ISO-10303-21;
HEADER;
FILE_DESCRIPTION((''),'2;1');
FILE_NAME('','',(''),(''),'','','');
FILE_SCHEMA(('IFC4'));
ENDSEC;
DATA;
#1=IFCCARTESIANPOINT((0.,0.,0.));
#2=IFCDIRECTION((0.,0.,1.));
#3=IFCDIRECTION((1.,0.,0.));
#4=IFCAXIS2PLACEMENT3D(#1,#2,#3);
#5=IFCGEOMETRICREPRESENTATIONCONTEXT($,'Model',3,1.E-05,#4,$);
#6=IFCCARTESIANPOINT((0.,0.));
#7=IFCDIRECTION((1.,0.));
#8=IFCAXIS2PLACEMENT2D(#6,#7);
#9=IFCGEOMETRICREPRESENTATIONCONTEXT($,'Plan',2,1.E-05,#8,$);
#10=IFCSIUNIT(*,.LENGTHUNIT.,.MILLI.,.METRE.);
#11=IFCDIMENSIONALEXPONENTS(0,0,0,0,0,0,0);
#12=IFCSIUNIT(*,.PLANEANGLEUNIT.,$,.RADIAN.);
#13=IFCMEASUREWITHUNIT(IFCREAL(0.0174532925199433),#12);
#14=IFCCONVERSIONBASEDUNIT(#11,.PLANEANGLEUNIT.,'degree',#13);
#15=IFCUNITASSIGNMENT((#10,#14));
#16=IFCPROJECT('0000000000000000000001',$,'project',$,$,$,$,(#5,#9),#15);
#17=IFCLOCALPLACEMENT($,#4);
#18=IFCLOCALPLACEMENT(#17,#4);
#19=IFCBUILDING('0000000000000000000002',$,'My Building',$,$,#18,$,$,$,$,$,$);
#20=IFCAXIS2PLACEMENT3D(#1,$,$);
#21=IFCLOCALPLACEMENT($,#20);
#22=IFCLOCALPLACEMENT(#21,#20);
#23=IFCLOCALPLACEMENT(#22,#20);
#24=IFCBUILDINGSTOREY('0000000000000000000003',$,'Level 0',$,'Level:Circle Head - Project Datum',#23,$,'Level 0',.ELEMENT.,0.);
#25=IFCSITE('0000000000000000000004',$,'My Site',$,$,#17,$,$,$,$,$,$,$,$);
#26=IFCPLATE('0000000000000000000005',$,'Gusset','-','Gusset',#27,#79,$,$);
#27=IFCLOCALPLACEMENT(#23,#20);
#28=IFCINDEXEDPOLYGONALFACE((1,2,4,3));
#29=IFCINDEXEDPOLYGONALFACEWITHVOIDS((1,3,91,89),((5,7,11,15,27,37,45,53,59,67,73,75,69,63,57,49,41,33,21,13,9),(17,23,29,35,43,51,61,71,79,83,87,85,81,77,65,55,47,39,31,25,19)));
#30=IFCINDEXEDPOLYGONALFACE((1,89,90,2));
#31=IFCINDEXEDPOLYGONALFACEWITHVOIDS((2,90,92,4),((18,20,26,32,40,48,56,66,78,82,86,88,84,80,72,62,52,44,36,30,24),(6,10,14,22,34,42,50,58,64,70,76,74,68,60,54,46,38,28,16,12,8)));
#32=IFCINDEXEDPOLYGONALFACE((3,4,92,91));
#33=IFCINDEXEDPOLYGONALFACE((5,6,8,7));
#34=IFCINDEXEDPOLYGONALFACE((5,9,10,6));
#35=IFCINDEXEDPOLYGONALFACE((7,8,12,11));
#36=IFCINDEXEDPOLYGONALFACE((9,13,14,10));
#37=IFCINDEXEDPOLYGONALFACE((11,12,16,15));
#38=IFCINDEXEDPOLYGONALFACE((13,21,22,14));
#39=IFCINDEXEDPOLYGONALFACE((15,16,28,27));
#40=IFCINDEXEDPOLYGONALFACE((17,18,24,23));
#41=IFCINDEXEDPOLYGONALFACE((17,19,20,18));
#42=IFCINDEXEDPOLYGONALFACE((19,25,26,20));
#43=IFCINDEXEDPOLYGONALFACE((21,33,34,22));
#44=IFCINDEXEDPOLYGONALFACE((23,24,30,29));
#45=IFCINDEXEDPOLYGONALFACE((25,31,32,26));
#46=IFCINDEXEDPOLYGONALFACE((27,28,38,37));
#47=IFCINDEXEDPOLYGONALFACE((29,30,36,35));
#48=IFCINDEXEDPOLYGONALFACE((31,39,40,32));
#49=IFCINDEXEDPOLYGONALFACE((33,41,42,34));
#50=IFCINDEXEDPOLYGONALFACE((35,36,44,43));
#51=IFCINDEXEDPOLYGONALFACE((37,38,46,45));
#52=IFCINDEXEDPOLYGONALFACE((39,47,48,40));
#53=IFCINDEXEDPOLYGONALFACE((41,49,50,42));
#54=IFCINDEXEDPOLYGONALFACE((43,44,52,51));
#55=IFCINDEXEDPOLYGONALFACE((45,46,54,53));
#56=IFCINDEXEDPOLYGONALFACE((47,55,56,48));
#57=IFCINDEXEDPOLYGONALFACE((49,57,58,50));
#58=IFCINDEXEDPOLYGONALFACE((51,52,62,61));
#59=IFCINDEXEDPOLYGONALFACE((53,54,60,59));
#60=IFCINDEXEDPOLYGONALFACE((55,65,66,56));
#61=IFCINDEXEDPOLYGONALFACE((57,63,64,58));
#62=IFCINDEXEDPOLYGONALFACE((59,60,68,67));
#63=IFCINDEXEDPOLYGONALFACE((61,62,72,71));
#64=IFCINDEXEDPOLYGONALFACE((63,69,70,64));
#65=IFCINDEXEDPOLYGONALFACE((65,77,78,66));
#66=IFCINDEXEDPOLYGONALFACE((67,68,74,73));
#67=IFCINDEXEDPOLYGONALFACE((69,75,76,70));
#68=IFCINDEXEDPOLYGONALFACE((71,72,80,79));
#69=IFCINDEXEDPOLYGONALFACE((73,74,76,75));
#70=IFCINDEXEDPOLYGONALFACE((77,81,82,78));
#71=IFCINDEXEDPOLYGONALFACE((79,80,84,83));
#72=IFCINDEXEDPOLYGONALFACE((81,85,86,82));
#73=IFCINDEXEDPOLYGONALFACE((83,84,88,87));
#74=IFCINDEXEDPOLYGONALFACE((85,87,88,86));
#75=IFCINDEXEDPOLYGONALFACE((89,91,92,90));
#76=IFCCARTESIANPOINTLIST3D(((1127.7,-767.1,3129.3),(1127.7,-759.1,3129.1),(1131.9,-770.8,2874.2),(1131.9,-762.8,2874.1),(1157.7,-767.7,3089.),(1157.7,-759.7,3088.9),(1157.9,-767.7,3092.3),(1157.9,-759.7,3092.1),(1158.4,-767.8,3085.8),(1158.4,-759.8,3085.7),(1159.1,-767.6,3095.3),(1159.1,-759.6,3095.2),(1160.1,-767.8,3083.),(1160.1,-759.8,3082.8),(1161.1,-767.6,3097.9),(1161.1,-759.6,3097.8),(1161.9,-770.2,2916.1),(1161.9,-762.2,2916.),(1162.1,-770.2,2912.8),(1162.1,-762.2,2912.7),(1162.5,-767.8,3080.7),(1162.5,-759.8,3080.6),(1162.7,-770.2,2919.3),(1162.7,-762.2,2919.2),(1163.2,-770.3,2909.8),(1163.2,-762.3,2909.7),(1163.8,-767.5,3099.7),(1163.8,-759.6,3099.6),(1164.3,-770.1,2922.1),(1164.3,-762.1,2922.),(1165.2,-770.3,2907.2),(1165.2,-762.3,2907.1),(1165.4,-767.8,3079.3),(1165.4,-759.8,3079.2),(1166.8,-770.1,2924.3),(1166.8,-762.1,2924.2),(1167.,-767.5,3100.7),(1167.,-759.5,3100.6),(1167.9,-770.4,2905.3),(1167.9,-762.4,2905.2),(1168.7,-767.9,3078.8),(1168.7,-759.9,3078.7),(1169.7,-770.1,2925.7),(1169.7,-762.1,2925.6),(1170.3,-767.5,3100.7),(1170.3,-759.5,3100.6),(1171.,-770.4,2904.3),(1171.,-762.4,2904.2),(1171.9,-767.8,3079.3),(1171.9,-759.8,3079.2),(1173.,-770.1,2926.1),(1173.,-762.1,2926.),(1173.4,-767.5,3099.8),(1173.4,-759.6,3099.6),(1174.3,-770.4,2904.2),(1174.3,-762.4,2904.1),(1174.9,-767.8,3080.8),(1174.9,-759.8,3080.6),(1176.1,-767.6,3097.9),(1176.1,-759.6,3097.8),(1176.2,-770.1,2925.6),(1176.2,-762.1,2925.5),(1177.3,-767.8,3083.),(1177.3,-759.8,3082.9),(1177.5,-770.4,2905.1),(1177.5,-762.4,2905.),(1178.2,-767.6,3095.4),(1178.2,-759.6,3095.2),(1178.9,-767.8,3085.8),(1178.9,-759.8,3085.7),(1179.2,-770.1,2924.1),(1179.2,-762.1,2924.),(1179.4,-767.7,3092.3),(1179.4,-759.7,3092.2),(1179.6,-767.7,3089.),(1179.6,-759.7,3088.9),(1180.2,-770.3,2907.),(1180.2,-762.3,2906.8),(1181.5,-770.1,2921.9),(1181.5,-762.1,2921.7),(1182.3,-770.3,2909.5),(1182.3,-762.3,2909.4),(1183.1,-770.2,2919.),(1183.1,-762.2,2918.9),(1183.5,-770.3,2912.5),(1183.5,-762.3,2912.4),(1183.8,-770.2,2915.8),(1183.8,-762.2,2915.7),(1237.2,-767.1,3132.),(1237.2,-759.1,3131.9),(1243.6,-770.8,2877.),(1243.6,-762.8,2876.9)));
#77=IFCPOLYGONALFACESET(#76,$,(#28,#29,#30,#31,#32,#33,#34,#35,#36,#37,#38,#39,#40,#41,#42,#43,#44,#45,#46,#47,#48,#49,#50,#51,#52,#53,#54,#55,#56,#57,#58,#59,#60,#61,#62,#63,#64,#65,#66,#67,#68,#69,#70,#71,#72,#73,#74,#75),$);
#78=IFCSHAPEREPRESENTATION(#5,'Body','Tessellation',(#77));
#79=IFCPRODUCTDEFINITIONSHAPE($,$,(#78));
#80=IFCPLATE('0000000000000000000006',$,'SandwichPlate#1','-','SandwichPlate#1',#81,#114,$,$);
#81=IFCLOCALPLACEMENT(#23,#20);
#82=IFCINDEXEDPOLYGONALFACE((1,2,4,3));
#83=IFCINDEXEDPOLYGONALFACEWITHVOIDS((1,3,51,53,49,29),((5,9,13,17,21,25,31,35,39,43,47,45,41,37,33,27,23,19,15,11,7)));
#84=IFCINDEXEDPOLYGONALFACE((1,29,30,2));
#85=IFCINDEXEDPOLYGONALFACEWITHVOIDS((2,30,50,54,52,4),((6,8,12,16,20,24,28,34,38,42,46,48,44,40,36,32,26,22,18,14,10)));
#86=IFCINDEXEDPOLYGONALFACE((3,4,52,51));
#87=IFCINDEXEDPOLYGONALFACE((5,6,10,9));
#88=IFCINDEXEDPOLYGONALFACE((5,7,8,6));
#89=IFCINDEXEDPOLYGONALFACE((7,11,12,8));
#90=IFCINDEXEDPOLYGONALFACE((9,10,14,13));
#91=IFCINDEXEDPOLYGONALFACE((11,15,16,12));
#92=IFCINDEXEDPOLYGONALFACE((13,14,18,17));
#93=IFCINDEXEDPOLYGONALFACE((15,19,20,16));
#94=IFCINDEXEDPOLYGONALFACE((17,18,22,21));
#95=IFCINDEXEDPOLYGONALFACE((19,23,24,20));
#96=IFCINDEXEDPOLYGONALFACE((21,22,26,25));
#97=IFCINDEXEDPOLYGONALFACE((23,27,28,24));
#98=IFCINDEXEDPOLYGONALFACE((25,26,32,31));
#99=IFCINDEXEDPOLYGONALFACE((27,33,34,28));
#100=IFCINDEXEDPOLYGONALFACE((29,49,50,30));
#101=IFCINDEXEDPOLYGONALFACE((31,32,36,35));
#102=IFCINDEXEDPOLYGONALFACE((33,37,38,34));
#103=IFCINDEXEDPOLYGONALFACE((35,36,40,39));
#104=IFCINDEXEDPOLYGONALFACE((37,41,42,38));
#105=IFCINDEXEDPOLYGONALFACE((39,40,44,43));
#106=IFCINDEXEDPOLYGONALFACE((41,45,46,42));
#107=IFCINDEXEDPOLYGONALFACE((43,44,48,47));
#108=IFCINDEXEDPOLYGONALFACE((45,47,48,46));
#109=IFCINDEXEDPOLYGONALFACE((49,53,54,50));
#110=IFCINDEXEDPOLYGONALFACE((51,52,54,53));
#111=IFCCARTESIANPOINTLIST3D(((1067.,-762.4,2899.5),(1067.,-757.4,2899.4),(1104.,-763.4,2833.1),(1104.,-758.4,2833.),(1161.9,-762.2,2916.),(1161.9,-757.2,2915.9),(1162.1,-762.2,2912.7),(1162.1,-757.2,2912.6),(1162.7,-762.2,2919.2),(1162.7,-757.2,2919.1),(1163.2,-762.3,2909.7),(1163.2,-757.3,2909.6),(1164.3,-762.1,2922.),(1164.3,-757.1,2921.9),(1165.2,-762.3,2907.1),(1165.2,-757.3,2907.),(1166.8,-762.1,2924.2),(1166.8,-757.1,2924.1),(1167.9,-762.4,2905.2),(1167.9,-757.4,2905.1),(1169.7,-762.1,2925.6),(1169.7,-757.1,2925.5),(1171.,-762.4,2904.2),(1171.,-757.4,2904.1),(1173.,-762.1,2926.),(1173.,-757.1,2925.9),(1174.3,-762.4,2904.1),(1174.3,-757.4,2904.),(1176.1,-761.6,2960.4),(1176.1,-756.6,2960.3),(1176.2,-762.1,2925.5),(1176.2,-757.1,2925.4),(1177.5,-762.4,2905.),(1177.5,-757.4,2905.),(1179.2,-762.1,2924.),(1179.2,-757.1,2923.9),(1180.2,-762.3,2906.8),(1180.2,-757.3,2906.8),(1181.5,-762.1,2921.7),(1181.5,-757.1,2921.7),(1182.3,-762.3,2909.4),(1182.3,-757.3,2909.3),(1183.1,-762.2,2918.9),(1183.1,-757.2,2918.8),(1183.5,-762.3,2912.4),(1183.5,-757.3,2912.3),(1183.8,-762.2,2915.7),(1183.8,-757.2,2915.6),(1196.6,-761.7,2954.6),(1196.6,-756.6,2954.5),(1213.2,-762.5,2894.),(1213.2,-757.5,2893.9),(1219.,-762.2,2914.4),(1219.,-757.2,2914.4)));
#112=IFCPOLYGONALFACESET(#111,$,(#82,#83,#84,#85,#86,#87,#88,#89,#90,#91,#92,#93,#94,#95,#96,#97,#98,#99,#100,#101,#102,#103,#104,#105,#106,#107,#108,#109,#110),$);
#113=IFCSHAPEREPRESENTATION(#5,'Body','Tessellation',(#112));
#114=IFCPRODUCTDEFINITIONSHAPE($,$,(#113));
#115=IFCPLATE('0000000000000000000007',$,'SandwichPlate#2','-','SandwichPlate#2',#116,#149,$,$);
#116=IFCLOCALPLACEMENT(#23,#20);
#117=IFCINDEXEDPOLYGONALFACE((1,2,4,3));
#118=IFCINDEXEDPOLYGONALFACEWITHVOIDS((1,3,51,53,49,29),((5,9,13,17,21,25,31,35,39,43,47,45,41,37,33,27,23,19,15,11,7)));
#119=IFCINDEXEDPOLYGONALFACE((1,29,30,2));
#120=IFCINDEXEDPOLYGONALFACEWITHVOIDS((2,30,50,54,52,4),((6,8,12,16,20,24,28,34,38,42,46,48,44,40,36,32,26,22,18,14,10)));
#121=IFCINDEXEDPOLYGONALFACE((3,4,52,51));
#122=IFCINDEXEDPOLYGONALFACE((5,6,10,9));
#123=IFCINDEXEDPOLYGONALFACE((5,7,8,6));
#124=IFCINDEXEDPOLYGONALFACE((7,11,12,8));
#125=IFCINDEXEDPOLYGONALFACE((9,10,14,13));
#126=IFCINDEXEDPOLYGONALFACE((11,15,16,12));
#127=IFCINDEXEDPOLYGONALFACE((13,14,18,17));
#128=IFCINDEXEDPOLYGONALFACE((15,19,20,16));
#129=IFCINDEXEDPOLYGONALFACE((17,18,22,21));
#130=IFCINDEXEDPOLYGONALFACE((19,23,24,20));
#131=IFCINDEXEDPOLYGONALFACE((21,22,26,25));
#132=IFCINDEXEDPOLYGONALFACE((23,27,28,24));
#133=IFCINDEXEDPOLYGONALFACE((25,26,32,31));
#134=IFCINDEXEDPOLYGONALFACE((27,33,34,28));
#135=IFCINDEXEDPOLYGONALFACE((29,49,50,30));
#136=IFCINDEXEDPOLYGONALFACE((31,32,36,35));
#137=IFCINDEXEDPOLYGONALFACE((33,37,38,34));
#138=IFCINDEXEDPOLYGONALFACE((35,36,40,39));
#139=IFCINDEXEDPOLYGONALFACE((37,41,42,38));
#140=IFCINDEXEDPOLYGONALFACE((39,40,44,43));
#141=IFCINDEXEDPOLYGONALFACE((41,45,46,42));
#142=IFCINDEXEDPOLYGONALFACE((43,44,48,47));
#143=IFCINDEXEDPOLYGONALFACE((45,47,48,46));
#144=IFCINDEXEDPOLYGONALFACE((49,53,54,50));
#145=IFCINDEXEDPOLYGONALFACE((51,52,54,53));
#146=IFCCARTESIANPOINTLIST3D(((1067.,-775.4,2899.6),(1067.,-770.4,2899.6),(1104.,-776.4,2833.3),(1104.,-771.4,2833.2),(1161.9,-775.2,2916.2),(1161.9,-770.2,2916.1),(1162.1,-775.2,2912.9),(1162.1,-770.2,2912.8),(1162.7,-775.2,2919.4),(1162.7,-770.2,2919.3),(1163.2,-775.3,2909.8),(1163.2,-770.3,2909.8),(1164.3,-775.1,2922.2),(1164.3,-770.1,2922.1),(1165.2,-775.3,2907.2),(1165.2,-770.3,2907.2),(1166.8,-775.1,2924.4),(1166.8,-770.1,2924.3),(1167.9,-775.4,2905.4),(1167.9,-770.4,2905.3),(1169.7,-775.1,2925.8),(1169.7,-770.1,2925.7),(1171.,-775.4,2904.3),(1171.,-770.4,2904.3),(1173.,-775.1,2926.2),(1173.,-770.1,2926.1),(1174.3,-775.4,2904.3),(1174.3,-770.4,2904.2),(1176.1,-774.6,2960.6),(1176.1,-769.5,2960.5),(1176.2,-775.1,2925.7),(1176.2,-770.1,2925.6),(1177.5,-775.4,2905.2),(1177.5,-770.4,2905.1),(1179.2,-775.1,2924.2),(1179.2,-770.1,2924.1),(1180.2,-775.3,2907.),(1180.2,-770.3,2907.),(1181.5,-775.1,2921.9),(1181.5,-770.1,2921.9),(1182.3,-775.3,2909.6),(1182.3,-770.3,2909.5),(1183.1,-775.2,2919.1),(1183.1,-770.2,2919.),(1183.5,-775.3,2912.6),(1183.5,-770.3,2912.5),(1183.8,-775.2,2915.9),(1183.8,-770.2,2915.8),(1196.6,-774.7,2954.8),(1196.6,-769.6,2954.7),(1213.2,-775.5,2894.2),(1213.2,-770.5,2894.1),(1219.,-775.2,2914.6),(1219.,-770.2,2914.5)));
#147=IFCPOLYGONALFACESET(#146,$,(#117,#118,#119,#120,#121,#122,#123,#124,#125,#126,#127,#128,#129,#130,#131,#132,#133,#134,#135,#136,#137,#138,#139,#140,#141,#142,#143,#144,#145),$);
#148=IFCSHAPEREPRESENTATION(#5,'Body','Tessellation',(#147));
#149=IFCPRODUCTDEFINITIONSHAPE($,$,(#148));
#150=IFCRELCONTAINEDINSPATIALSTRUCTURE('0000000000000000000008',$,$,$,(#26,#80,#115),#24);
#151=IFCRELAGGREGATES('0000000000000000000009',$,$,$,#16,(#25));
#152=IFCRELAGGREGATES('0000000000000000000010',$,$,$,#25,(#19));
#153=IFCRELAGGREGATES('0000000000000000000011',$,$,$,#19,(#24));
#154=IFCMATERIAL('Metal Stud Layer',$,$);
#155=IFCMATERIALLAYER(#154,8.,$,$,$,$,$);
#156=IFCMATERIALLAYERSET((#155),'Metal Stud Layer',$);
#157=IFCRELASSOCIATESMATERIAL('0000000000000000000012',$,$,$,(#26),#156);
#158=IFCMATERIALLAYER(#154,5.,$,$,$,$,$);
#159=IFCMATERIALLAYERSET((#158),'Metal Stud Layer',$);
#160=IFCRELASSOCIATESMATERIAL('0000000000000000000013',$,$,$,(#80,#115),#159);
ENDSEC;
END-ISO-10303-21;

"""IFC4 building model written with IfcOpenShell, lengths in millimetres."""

from ifc_helpers import new_model, entity, si_unit, converted_unit, frame, origin, origin_with_axes, origin_2d_with_axis, place, context, project, spatial, polyline, circle, outline, extrude, material, layer, layer_set, element, save


model = new_model("IFC4")

# Units and contexts
model_context = context("Model", 3, precision=1e-05, world=origin_with_axes())
plan_context = context("Plan", 2, precision=1e-05, world=origin_2d_with_axis())
ifc_project = project(units=[si_unit("LENGTHUNIT", "METRE", prefix="MILLI"), converted_unit("PLANEANGLEUNIT", "degree", entity("IfcReal", 0.0174532925199433), si_unit("PLANEANGLEUNIT", "RADIAN"), dimensions=[0, 0, 0, 0, 0, 0, 0])], contexts=[model_context, plan_context])

# Site, building, storey
site_placement = place(None, origin_with_axes())
site = spatial("IfcSite", under=ifc_project, at=site_placement, Name="My Site")
building_placement = place(site_placement, origin_with_axes())
building = spatial("IfcBuilding", under=site, at=building_placement, Name="My Building")
placement_1 = place(None, origin())
placement_2 = place(placement_1, origin())
storey_placement = place(placement_2, origin())
storey = spatial("IfcBuildingStorey", under=building, at=storey_placement, Name="Level 0", ObjectType="Level:Circle Head - Project Datum", LongName="Level 0", CompositionType="ELEMENT", Elevation=0.0)

# Plates, openings
ifc_material = material(Name="Metal Stud Layer")
ifc_layer_1 = layer(ifc_material, 8.0)
ifc_layer_set_1 = layer_set([ifc_layer_1], Name="Metal Stud Layer")
plate_1_placement = place(storey_placement, frame((1235.2, -767.1, 3131.9), z_axis=(0.0, 0.999896, -0.014432), x_axis=(0.02499, -0.014428, -0.999584)))
plate_1 = element("IfcPlate", 1, at=plate_1_placement, inside=storey, material=ifc_layer_set_1, Name="Gusset", Description="-", ObjectType="Gusset", context=model_context, shape_type="SweptSolid", body=[
    extrude(outline(polyline([(0.0, -2.0), (255.1, -2.0), (255.1, 109.7), (0.0, 107.5), (0.0, -2.0)])), origin_with_axes(), (0.0, 0.0, 1.0), 8.0),
])
opening_1_placement = place(plate_1_placement, frame((215.2, 67.8, 8.5), z_axis=(0.0, 0.0, -1.0), x_axis=(0.465432, 0.885083, 0.0)))
element("IfcOpeningElement", 2, at=opening_1_placement, cuts=plate_1, ObjectType="Opening", context=model_context, shape_type="SweptSolid", body=[
    extrude(circle(Radius=11.0, at=origin_2d_with_axis()), origin(), (0.0, 0.0, 1.0), 9.0),
])
opening_2_placement = place(plate_1_placement, frame((40.4, 67.6, 8.5), z_axis=(0.0, 0.0, -1.0), x_axis=(-0.51948, 0.854483, 0.0)))
element("IfcOpeningElement", 3, at=opening_2_placement, cuts=plate_1, ObjectType="Opening", context=model_context, shape_type="SweptSolid", body=[
    extrude(circle(Radius=11.0, at=origin_2d_with_axis()), origin(), (0.0, 0.0, 1.0), 9.0),
])
ifc_layer_2 = layer(ifc_material, 5.0)
ifc_layer_set_2 = layer_set([ifc_layer_2], Name="Metal Stud Layer")
plate_2_placement = place(storey_placement, frame((1226.3, -757.4, 2901.3), z_axis=(0.0, -0.999896, 0.014432), x_axis=(-0.487405, 0.012602, 0.873085)))
plate_2 = element("IfcPlate", 4, at=plate_2_placement, inside=storey, material=ifc_layer_set_2, Name="SandwichPlate#1", Description="-", ObjectType="SandwichPlate#1", context=model_context, shape_type="SweptSolid", body=[
    extrude(outline(polyline([(0.0, 0.0), (76.0, 0.0), (76.0, 140.0), (0.0, 140.0), (0.0, 0.0)])), origin_with_axes(), (0.0, 0.0, 1.0), 5.0),
])
opening_3_placement = place(plate_2_placement, frame((38.0, 40.0, -0.5), z_axis=(0.0, 0.0, 1.0), x_axis=(0.0, 1.0, 0.0)))
element("IfcOpeningElement", 5, at=opening_3_placement, cuts=plate_2, ObjectType="Opening", context=model_context, shape_type="SweptSolid", body=[
    extrude(circle(Radius=11.0, at=origin_2d_with_axis()), origin(), (0.0, 0.0, 1.0), 6.0),
])
opening_4_placement = place(plate_2_placement, frame((0.0, 0.0, 0.0), z_axis=(0.0, 0.0, 1.0), x_axis=(1.0, 0.0, 0.0)))
element("IfcOpeningElement", 6, at=opening_4_placement, cuts=plate_2, ObjectType="Opening", context=model_context, shape_type="SweptSolid", body=[
    extrude(outline(polyline([(0.0, 0.0), (15.0, 0.0), (0.0, 15.0), (0.0, 0.0)])), origin(), (0.0, 0.0, 1.0), 5.0),
])
opening_5_placement = place(plate_2_placement, frame((0.0, 0.0, 0.0), z_axis=(0.0, 0.0, 1.0), x_axis=(1.0, 0.0, 0.0)))
element("IfcOpeningElement", 7, at=opening_5_placement, cuts=plate_2, ObjectType="Opening", context=model_context, shape_type="SweptSolid", body=[
    extrude(outline(polyline([(76.0, 0.0), (76.0, 15.0), (61.0, 0.0), (76.0, 0.0)])), origin(), (0.0, 0.0, 1.0), 5.0),
])
plate_3_placement = place(storey_placement, frame((1226.3, -770.4, 2901.4), z_axis=(0.0, -0.999896, 0.014432), x_axis=(-0.487405, 0.012602, 0.873085)))
plate_3 = element("IfcPlate", 8, at=plate_3_placement, inside=storey, material=ifc_layer_set_2, Name="SandwichPlate#2", Description="-", ObjectType="SandwichPlate#2", context=model_context, shape_type="SweptSolid", body=[
    extrude(outline(polyline([(0.0, 0.0), (76.0, 0.0), (76.0, 140.0), (0.0, 140.0), (0.0, 0.0)])), origin_with_axes(), (0.0, 0.0, 1.0), 5.0),
])
opening_6_placement = place(plate_3_placement, frame((38.0, 40.0, -0.5), z_axis=(0.0, 0.0, 1.0), x_axis=(0.0, 1.0, 0.0)))
element("IfcOpeningElement", 9, at=opening_6_placement, cuts=plate_3, ObjectType="Opening", context=model_context, shape_type="SweptSolid", body=[
    extrude(circle(Radius=11.0, at=origin_2d_with_axis()), origin(), (0.0, 0.0, 1.0), 6.0),
])
opening_7_placement = place(plate_3_placement, frame((0.0, 0.0, 0.0), z_axis=(0.0, 0.0, 1.0), x_axis=(1.0, 0.0, 0.0)))
element("IfcOpeningElement", 10, at=opening_7_placement, cuts=plate_3, ObjectType="Opening", context=model_context, shape_type="SweptSolid", body=[
    extrude(outline(polyline([(0.0, 0.0), (15.0, 0.0), (0.0, 15.0), (0.0, 0.0)])), origin(), (0.0, 0.0, 1.0), 5.0),
])
opening_8_placement = place(plate_3_placement, frame((0.0, 0.0, 0.0), z_axis=(0.0, 0.0, 1.0), x_axis=(1.0, 0.0, 0.0)))
element("IfcOpeningElement", 11, at=opening_8_placement, cuts=plate_3, ObjectType="Opening", context=model_context, shape_type="SweptSolid", body=[
    extrude(outline(polyline([(76.0, 0.0), (76.0, 15.0), (61.0, 0.0), (76.0, 0.0)])), origin(), (0.0, 0.0, 1.0), 5.0),
])

save(model, "model.ifc")
